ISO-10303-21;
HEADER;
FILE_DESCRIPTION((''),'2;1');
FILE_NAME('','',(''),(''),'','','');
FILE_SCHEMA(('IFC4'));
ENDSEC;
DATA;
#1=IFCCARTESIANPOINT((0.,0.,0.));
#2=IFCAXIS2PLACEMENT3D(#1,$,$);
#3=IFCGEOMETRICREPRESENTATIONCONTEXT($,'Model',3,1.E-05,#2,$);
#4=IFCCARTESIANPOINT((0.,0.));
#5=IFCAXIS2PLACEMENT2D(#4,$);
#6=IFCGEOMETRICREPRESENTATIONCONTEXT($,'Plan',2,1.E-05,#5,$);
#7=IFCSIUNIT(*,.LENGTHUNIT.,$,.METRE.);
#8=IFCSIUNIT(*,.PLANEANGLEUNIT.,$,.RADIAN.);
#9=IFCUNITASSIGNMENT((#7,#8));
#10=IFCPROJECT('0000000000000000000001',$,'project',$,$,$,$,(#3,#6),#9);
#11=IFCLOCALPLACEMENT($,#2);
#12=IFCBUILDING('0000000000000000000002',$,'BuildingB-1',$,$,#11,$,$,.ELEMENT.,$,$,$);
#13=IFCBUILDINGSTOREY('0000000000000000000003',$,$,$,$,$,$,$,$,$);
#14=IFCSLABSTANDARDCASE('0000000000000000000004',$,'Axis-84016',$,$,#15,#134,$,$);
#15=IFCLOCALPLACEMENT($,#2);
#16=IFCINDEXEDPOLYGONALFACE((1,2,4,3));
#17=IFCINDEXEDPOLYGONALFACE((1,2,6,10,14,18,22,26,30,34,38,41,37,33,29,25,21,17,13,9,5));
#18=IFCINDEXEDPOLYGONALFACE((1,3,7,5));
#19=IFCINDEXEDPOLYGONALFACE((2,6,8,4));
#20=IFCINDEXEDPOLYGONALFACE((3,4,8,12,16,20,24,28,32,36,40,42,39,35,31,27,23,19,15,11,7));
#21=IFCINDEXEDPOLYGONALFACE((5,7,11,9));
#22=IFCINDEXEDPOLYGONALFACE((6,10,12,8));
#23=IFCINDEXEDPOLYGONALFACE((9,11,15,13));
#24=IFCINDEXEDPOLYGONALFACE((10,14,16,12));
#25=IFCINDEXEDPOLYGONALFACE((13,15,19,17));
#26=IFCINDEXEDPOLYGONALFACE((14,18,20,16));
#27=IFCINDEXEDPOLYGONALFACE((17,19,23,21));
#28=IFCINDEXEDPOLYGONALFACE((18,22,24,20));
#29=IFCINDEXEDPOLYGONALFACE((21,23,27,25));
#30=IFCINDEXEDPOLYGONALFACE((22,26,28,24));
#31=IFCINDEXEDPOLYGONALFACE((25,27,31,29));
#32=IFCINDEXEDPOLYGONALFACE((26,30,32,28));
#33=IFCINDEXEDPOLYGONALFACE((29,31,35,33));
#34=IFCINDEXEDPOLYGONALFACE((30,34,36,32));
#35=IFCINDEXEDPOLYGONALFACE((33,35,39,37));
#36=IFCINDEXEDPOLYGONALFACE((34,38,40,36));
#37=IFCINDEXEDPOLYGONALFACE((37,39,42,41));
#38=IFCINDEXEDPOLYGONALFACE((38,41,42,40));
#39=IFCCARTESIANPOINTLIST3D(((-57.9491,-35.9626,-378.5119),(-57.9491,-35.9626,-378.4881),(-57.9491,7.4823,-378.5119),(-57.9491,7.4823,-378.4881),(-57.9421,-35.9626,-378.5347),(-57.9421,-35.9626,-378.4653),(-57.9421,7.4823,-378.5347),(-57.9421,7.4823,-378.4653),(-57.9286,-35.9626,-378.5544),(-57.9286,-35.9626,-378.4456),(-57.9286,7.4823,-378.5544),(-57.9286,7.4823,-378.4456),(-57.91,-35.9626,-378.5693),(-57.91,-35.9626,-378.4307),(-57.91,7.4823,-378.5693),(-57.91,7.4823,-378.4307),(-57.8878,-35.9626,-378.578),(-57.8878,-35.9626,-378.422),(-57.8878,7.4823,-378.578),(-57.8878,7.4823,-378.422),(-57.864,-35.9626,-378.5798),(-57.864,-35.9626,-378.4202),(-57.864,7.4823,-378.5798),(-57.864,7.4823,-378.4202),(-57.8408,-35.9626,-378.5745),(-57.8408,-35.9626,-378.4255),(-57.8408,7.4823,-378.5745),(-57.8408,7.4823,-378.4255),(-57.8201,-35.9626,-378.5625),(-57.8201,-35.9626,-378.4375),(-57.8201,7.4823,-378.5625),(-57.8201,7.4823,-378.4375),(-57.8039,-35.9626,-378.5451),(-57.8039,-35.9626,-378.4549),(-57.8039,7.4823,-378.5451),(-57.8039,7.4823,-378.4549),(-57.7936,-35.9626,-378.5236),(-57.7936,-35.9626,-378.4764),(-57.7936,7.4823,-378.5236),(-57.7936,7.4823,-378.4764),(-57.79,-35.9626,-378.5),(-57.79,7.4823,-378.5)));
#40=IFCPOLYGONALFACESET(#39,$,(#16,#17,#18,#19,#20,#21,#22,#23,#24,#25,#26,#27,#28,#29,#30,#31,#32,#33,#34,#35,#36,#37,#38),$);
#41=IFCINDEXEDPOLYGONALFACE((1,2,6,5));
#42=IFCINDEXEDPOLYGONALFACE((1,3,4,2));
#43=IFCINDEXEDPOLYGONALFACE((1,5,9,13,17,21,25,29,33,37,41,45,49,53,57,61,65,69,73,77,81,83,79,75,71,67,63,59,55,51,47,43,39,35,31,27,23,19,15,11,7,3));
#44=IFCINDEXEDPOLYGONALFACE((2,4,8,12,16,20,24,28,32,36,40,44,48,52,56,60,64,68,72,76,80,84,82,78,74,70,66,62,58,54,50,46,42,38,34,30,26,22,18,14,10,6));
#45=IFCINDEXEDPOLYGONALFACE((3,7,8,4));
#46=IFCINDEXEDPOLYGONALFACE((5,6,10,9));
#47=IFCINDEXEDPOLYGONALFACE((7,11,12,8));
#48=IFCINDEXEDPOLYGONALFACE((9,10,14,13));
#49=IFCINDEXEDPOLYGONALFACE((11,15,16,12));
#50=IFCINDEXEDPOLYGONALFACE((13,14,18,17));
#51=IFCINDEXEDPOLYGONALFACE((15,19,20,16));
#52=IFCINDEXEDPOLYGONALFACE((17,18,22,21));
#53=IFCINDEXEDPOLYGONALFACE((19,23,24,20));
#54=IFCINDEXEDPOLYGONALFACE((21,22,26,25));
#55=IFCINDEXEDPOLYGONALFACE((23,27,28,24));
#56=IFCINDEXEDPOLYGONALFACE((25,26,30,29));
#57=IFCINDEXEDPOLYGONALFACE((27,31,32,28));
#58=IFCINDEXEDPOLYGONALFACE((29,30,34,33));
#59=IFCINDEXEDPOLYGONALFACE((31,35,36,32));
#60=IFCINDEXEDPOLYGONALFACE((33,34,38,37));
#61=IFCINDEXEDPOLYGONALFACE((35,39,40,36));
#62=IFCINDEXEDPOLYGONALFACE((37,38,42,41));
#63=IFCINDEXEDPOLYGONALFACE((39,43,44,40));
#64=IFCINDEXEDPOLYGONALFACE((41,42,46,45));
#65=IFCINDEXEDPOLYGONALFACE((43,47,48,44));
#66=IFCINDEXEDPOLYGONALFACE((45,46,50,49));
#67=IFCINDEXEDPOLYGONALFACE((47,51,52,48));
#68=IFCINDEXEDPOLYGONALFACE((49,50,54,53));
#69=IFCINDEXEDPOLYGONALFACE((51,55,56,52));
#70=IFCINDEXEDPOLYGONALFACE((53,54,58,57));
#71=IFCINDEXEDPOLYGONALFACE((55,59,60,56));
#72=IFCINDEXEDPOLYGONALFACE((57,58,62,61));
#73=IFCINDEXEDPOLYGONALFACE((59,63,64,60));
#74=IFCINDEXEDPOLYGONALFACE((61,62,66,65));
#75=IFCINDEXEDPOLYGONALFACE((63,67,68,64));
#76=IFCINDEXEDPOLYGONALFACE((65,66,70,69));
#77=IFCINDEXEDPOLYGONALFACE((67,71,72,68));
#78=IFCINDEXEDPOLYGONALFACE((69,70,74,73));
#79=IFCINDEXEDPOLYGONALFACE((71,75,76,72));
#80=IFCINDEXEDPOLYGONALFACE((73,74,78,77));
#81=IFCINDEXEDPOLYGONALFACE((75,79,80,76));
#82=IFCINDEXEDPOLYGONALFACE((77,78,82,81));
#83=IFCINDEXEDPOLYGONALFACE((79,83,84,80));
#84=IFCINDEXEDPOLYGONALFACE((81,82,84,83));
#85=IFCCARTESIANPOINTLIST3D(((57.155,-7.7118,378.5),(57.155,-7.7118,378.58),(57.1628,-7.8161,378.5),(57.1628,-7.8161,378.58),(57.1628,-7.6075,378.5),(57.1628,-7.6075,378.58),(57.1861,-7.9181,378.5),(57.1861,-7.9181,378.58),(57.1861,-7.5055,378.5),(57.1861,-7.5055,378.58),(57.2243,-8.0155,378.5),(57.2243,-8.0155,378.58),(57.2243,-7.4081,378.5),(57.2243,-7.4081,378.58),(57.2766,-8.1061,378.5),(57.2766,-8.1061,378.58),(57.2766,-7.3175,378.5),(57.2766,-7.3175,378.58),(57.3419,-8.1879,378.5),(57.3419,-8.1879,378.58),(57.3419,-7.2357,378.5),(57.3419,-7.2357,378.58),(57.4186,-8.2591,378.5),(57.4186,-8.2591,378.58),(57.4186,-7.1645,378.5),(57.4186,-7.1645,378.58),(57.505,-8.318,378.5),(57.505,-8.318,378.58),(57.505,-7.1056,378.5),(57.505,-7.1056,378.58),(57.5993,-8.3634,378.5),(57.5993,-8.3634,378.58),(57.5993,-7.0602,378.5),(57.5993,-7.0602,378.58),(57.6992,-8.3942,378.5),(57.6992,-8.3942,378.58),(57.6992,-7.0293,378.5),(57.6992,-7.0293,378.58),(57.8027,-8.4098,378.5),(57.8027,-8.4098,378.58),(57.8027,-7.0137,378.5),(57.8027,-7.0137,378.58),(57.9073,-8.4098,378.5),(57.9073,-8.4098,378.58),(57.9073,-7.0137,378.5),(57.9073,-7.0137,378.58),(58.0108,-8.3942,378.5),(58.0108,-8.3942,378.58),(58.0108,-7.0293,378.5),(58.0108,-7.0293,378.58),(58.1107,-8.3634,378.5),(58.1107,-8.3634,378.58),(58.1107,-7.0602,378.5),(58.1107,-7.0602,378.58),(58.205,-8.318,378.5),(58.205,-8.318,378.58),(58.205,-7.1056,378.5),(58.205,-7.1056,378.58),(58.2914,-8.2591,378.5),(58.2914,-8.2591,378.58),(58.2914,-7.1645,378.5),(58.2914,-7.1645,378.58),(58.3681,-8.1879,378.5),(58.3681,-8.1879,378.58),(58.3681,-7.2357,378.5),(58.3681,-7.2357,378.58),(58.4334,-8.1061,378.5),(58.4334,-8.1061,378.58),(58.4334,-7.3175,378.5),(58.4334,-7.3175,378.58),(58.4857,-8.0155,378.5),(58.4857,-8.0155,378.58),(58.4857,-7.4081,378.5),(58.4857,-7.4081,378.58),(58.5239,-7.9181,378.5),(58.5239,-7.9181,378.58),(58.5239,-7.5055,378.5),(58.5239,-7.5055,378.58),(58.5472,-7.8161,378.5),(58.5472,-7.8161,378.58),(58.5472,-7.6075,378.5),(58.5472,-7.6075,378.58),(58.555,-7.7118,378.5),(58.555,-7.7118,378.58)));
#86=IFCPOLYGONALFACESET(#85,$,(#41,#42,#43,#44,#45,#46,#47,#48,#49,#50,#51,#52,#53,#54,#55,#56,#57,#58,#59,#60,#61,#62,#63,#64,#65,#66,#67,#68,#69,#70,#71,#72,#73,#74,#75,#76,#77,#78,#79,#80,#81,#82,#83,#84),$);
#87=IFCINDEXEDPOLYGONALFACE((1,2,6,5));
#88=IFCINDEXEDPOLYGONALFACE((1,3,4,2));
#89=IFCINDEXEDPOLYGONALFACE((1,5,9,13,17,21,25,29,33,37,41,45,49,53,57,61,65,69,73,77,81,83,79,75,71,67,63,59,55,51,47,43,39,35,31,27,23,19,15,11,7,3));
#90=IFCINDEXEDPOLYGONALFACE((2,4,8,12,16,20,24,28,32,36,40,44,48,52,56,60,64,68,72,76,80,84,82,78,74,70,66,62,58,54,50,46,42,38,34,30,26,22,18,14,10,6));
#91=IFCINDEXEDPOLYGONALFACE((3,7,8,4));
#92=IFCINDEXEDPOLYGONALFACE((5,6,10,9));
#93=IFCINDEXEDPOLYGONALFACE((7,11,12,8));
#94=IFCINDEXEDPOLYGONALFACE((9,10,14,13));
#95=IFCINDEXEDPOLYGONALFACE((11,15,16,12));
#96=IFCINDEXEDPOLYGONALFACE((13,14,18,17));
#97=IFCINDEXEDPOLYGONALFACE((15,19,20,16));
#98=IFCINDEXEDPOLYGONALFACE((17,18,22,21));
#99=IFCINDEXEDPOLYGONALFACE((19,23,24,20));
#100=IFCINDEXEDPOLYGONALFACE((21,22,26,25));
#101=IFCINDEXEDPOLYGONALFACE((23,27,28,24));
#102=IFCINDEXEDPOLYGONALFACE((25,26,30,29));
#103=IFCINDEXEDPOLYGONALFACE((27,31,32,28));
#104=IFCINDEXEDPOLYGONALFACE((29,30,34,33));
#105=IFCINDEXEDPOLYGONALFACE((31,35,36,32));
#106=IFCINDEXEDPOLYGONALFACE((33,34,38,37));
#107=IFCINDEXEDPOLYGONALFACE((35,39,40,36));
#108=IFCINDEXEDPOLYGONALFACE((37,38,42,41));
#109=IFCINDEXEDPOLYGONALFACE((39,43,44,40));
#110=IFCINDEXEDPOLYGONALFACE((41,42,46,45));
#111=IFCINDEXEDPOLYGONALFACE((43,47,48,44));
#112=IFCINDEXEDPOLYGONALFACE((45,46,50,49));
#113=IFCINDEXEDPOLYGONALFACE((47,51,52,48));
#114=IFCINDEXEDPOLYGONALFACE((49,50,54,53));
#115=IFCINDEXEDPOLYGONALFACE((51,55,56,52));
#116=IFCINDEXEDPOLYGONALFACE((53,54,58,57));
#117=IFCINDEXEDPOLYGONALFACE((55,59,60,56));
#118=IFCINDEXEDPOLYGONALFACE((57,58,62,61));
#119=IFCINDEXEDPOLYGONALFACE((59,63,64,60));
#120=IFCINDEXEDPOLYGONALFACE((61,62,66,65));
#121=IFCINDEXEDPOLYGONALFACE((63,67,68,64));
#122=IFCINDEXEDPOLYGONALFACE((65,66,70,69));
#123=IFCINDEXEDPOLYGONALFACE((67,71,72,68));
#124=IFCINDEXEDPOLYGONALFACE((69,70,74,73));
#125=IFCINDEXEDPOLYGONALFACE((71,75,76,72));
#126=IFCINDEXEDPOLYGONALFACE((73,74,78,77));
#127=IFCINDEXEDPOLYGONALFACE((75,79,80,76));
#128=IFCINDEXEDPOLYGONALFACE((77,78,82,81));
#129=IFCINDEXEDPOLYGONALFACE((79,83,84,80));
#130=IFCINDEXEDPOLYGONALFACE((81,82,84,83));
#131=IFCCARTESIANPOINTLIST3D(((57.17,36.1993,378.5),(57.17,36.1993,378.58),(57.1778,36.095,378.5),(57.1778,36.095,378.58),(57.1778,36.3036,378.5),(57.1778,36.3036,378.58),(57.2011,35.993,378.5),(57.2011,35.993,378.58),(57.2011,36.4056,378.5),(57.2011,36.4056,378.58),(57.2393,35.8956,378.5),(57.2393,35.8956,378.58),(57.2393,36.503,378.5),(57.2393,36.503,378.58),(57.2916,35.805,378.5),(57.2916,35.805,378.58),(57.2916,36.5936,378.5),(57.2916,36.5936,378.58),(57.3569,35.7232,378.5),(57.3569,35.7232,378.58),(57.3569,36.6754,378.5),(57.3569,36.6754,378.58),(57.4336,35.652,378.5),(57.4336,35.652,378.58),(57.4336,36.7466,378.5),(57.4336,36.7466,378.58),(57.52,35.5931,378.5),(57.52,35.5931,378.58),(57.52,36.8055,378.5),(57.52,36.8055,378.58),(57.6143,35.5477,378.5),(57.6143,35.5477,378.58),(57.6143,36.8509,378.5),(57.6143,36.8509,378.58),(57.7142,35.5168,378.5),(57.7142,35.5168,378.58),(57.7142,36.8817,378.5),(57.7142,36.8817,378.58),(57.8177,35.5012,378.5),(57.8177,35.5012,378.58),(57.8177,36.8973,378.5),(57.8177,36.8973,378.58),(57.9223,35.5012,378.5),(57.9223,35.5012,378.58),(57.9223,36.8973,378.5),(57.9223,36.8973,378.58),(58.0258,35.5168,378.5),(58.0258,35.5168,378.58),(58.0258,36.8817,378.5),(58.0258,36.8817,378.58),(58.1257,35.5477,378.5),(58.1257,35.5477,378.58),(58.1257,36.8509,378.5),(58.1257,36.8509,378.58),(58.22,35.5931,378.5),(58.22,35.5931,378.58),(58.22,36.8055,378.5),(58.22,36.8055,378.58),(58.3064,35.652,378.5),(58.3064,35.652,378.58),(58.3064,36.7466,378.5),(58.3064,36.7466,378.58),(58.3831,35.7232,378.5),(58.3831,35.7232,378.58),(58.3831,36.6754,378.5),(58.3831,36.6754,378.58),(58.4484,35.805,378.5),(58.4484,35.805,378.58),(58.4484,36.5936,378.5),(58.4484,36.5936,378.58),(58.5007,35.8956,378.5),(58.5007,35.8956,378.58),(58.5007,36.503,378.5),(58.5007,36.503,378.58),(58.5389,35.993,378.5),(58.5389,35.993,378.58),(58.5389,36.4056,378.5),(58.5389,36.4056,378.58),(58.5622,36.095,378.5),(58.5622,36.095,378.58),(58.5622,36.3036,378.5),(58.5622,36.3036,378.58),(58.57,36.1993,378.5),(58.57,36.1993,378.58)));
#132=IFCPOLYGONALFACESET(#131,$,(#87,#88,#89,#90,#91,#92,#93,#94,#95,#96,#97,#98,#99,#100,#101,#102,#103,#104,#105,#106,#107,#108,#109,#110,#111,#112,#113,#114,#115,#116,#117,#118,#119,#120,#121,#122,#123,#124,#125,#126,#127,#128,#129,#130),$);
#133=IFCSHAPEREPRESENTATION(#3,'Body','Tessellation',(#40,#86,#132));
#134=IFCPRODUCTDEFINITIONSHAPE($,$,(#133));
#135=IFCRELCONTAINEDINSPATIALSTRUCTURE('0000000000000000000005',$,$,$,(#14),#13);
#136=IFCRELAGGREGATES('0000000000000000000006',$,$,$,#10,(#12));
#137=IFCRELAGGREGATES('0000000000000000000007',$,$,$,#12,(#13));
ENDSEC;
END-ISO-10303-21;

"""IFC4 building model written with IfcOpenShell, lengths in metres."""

from ifc_helpers import new_model, entity, si_unit, frame, origin, origin_2d, place, context, project, spatial, circle, extrude, element, save


model = new_model("IFC4")

# Units and contexts
model_context = context("Model", 3, precision=1e-05, world=origin())
plan_context = context("Plan", 2, precision=1e-05, world=origin_2d())
ifc_project = project(units=[si_unit("LENGTHUNIT", "METRE"), si_unit("PLANEANGLEUNIT", "RADIAN")], contexts=[model_context, plan_context])

# Building, storey
building_placement = place(None, origin())
building = spatial("IfcBuilding", under=ifc_project, at=building_placement, Name="BuildingB-1", CompositionType="ELEMENT")
storey = spatial("IfcBuildingStorey", under=building)

# Slab
element("IfcSlabStandardCase", 1, inside=storey, Name="Axis-84016", context=model_context, shape_type="AdvancedSweptSolid", body=[
    entity("IfcSurfaceCurveSweptAreaSolid", entity("IfcCircleProfileDef", "AREA", None, None, 0.08), None, entity("IfcPolyline", [entity("IfcCartesianPoint", [57.87, -7.4823, 378.5]), entity("IfcCartesianPoint", [57.87, 35.9626, 378.5])]), None, None, entity("IfcPlane", entity("IfcAxis2Placement3D", entity("IfcCartesianPoint", [57.87, -7.4823, 378.5]), entity("IfcDirection", [0.0, 0.0, 1.0]), entity("IfcDirection", [1.0, 0.0, 0.0])))),
    extrude(circle(Radius=0.7), frame((57.855, -7.7118, 378.5)), (0.0, 0.0, 1.0), 0.08),
    extrude(circle(Radius=0.7), frame((57.87, 36.1993, 378.5)), (0.0, 0.0, 1.0), 0.08),
])

save(model, "model.ifc")
